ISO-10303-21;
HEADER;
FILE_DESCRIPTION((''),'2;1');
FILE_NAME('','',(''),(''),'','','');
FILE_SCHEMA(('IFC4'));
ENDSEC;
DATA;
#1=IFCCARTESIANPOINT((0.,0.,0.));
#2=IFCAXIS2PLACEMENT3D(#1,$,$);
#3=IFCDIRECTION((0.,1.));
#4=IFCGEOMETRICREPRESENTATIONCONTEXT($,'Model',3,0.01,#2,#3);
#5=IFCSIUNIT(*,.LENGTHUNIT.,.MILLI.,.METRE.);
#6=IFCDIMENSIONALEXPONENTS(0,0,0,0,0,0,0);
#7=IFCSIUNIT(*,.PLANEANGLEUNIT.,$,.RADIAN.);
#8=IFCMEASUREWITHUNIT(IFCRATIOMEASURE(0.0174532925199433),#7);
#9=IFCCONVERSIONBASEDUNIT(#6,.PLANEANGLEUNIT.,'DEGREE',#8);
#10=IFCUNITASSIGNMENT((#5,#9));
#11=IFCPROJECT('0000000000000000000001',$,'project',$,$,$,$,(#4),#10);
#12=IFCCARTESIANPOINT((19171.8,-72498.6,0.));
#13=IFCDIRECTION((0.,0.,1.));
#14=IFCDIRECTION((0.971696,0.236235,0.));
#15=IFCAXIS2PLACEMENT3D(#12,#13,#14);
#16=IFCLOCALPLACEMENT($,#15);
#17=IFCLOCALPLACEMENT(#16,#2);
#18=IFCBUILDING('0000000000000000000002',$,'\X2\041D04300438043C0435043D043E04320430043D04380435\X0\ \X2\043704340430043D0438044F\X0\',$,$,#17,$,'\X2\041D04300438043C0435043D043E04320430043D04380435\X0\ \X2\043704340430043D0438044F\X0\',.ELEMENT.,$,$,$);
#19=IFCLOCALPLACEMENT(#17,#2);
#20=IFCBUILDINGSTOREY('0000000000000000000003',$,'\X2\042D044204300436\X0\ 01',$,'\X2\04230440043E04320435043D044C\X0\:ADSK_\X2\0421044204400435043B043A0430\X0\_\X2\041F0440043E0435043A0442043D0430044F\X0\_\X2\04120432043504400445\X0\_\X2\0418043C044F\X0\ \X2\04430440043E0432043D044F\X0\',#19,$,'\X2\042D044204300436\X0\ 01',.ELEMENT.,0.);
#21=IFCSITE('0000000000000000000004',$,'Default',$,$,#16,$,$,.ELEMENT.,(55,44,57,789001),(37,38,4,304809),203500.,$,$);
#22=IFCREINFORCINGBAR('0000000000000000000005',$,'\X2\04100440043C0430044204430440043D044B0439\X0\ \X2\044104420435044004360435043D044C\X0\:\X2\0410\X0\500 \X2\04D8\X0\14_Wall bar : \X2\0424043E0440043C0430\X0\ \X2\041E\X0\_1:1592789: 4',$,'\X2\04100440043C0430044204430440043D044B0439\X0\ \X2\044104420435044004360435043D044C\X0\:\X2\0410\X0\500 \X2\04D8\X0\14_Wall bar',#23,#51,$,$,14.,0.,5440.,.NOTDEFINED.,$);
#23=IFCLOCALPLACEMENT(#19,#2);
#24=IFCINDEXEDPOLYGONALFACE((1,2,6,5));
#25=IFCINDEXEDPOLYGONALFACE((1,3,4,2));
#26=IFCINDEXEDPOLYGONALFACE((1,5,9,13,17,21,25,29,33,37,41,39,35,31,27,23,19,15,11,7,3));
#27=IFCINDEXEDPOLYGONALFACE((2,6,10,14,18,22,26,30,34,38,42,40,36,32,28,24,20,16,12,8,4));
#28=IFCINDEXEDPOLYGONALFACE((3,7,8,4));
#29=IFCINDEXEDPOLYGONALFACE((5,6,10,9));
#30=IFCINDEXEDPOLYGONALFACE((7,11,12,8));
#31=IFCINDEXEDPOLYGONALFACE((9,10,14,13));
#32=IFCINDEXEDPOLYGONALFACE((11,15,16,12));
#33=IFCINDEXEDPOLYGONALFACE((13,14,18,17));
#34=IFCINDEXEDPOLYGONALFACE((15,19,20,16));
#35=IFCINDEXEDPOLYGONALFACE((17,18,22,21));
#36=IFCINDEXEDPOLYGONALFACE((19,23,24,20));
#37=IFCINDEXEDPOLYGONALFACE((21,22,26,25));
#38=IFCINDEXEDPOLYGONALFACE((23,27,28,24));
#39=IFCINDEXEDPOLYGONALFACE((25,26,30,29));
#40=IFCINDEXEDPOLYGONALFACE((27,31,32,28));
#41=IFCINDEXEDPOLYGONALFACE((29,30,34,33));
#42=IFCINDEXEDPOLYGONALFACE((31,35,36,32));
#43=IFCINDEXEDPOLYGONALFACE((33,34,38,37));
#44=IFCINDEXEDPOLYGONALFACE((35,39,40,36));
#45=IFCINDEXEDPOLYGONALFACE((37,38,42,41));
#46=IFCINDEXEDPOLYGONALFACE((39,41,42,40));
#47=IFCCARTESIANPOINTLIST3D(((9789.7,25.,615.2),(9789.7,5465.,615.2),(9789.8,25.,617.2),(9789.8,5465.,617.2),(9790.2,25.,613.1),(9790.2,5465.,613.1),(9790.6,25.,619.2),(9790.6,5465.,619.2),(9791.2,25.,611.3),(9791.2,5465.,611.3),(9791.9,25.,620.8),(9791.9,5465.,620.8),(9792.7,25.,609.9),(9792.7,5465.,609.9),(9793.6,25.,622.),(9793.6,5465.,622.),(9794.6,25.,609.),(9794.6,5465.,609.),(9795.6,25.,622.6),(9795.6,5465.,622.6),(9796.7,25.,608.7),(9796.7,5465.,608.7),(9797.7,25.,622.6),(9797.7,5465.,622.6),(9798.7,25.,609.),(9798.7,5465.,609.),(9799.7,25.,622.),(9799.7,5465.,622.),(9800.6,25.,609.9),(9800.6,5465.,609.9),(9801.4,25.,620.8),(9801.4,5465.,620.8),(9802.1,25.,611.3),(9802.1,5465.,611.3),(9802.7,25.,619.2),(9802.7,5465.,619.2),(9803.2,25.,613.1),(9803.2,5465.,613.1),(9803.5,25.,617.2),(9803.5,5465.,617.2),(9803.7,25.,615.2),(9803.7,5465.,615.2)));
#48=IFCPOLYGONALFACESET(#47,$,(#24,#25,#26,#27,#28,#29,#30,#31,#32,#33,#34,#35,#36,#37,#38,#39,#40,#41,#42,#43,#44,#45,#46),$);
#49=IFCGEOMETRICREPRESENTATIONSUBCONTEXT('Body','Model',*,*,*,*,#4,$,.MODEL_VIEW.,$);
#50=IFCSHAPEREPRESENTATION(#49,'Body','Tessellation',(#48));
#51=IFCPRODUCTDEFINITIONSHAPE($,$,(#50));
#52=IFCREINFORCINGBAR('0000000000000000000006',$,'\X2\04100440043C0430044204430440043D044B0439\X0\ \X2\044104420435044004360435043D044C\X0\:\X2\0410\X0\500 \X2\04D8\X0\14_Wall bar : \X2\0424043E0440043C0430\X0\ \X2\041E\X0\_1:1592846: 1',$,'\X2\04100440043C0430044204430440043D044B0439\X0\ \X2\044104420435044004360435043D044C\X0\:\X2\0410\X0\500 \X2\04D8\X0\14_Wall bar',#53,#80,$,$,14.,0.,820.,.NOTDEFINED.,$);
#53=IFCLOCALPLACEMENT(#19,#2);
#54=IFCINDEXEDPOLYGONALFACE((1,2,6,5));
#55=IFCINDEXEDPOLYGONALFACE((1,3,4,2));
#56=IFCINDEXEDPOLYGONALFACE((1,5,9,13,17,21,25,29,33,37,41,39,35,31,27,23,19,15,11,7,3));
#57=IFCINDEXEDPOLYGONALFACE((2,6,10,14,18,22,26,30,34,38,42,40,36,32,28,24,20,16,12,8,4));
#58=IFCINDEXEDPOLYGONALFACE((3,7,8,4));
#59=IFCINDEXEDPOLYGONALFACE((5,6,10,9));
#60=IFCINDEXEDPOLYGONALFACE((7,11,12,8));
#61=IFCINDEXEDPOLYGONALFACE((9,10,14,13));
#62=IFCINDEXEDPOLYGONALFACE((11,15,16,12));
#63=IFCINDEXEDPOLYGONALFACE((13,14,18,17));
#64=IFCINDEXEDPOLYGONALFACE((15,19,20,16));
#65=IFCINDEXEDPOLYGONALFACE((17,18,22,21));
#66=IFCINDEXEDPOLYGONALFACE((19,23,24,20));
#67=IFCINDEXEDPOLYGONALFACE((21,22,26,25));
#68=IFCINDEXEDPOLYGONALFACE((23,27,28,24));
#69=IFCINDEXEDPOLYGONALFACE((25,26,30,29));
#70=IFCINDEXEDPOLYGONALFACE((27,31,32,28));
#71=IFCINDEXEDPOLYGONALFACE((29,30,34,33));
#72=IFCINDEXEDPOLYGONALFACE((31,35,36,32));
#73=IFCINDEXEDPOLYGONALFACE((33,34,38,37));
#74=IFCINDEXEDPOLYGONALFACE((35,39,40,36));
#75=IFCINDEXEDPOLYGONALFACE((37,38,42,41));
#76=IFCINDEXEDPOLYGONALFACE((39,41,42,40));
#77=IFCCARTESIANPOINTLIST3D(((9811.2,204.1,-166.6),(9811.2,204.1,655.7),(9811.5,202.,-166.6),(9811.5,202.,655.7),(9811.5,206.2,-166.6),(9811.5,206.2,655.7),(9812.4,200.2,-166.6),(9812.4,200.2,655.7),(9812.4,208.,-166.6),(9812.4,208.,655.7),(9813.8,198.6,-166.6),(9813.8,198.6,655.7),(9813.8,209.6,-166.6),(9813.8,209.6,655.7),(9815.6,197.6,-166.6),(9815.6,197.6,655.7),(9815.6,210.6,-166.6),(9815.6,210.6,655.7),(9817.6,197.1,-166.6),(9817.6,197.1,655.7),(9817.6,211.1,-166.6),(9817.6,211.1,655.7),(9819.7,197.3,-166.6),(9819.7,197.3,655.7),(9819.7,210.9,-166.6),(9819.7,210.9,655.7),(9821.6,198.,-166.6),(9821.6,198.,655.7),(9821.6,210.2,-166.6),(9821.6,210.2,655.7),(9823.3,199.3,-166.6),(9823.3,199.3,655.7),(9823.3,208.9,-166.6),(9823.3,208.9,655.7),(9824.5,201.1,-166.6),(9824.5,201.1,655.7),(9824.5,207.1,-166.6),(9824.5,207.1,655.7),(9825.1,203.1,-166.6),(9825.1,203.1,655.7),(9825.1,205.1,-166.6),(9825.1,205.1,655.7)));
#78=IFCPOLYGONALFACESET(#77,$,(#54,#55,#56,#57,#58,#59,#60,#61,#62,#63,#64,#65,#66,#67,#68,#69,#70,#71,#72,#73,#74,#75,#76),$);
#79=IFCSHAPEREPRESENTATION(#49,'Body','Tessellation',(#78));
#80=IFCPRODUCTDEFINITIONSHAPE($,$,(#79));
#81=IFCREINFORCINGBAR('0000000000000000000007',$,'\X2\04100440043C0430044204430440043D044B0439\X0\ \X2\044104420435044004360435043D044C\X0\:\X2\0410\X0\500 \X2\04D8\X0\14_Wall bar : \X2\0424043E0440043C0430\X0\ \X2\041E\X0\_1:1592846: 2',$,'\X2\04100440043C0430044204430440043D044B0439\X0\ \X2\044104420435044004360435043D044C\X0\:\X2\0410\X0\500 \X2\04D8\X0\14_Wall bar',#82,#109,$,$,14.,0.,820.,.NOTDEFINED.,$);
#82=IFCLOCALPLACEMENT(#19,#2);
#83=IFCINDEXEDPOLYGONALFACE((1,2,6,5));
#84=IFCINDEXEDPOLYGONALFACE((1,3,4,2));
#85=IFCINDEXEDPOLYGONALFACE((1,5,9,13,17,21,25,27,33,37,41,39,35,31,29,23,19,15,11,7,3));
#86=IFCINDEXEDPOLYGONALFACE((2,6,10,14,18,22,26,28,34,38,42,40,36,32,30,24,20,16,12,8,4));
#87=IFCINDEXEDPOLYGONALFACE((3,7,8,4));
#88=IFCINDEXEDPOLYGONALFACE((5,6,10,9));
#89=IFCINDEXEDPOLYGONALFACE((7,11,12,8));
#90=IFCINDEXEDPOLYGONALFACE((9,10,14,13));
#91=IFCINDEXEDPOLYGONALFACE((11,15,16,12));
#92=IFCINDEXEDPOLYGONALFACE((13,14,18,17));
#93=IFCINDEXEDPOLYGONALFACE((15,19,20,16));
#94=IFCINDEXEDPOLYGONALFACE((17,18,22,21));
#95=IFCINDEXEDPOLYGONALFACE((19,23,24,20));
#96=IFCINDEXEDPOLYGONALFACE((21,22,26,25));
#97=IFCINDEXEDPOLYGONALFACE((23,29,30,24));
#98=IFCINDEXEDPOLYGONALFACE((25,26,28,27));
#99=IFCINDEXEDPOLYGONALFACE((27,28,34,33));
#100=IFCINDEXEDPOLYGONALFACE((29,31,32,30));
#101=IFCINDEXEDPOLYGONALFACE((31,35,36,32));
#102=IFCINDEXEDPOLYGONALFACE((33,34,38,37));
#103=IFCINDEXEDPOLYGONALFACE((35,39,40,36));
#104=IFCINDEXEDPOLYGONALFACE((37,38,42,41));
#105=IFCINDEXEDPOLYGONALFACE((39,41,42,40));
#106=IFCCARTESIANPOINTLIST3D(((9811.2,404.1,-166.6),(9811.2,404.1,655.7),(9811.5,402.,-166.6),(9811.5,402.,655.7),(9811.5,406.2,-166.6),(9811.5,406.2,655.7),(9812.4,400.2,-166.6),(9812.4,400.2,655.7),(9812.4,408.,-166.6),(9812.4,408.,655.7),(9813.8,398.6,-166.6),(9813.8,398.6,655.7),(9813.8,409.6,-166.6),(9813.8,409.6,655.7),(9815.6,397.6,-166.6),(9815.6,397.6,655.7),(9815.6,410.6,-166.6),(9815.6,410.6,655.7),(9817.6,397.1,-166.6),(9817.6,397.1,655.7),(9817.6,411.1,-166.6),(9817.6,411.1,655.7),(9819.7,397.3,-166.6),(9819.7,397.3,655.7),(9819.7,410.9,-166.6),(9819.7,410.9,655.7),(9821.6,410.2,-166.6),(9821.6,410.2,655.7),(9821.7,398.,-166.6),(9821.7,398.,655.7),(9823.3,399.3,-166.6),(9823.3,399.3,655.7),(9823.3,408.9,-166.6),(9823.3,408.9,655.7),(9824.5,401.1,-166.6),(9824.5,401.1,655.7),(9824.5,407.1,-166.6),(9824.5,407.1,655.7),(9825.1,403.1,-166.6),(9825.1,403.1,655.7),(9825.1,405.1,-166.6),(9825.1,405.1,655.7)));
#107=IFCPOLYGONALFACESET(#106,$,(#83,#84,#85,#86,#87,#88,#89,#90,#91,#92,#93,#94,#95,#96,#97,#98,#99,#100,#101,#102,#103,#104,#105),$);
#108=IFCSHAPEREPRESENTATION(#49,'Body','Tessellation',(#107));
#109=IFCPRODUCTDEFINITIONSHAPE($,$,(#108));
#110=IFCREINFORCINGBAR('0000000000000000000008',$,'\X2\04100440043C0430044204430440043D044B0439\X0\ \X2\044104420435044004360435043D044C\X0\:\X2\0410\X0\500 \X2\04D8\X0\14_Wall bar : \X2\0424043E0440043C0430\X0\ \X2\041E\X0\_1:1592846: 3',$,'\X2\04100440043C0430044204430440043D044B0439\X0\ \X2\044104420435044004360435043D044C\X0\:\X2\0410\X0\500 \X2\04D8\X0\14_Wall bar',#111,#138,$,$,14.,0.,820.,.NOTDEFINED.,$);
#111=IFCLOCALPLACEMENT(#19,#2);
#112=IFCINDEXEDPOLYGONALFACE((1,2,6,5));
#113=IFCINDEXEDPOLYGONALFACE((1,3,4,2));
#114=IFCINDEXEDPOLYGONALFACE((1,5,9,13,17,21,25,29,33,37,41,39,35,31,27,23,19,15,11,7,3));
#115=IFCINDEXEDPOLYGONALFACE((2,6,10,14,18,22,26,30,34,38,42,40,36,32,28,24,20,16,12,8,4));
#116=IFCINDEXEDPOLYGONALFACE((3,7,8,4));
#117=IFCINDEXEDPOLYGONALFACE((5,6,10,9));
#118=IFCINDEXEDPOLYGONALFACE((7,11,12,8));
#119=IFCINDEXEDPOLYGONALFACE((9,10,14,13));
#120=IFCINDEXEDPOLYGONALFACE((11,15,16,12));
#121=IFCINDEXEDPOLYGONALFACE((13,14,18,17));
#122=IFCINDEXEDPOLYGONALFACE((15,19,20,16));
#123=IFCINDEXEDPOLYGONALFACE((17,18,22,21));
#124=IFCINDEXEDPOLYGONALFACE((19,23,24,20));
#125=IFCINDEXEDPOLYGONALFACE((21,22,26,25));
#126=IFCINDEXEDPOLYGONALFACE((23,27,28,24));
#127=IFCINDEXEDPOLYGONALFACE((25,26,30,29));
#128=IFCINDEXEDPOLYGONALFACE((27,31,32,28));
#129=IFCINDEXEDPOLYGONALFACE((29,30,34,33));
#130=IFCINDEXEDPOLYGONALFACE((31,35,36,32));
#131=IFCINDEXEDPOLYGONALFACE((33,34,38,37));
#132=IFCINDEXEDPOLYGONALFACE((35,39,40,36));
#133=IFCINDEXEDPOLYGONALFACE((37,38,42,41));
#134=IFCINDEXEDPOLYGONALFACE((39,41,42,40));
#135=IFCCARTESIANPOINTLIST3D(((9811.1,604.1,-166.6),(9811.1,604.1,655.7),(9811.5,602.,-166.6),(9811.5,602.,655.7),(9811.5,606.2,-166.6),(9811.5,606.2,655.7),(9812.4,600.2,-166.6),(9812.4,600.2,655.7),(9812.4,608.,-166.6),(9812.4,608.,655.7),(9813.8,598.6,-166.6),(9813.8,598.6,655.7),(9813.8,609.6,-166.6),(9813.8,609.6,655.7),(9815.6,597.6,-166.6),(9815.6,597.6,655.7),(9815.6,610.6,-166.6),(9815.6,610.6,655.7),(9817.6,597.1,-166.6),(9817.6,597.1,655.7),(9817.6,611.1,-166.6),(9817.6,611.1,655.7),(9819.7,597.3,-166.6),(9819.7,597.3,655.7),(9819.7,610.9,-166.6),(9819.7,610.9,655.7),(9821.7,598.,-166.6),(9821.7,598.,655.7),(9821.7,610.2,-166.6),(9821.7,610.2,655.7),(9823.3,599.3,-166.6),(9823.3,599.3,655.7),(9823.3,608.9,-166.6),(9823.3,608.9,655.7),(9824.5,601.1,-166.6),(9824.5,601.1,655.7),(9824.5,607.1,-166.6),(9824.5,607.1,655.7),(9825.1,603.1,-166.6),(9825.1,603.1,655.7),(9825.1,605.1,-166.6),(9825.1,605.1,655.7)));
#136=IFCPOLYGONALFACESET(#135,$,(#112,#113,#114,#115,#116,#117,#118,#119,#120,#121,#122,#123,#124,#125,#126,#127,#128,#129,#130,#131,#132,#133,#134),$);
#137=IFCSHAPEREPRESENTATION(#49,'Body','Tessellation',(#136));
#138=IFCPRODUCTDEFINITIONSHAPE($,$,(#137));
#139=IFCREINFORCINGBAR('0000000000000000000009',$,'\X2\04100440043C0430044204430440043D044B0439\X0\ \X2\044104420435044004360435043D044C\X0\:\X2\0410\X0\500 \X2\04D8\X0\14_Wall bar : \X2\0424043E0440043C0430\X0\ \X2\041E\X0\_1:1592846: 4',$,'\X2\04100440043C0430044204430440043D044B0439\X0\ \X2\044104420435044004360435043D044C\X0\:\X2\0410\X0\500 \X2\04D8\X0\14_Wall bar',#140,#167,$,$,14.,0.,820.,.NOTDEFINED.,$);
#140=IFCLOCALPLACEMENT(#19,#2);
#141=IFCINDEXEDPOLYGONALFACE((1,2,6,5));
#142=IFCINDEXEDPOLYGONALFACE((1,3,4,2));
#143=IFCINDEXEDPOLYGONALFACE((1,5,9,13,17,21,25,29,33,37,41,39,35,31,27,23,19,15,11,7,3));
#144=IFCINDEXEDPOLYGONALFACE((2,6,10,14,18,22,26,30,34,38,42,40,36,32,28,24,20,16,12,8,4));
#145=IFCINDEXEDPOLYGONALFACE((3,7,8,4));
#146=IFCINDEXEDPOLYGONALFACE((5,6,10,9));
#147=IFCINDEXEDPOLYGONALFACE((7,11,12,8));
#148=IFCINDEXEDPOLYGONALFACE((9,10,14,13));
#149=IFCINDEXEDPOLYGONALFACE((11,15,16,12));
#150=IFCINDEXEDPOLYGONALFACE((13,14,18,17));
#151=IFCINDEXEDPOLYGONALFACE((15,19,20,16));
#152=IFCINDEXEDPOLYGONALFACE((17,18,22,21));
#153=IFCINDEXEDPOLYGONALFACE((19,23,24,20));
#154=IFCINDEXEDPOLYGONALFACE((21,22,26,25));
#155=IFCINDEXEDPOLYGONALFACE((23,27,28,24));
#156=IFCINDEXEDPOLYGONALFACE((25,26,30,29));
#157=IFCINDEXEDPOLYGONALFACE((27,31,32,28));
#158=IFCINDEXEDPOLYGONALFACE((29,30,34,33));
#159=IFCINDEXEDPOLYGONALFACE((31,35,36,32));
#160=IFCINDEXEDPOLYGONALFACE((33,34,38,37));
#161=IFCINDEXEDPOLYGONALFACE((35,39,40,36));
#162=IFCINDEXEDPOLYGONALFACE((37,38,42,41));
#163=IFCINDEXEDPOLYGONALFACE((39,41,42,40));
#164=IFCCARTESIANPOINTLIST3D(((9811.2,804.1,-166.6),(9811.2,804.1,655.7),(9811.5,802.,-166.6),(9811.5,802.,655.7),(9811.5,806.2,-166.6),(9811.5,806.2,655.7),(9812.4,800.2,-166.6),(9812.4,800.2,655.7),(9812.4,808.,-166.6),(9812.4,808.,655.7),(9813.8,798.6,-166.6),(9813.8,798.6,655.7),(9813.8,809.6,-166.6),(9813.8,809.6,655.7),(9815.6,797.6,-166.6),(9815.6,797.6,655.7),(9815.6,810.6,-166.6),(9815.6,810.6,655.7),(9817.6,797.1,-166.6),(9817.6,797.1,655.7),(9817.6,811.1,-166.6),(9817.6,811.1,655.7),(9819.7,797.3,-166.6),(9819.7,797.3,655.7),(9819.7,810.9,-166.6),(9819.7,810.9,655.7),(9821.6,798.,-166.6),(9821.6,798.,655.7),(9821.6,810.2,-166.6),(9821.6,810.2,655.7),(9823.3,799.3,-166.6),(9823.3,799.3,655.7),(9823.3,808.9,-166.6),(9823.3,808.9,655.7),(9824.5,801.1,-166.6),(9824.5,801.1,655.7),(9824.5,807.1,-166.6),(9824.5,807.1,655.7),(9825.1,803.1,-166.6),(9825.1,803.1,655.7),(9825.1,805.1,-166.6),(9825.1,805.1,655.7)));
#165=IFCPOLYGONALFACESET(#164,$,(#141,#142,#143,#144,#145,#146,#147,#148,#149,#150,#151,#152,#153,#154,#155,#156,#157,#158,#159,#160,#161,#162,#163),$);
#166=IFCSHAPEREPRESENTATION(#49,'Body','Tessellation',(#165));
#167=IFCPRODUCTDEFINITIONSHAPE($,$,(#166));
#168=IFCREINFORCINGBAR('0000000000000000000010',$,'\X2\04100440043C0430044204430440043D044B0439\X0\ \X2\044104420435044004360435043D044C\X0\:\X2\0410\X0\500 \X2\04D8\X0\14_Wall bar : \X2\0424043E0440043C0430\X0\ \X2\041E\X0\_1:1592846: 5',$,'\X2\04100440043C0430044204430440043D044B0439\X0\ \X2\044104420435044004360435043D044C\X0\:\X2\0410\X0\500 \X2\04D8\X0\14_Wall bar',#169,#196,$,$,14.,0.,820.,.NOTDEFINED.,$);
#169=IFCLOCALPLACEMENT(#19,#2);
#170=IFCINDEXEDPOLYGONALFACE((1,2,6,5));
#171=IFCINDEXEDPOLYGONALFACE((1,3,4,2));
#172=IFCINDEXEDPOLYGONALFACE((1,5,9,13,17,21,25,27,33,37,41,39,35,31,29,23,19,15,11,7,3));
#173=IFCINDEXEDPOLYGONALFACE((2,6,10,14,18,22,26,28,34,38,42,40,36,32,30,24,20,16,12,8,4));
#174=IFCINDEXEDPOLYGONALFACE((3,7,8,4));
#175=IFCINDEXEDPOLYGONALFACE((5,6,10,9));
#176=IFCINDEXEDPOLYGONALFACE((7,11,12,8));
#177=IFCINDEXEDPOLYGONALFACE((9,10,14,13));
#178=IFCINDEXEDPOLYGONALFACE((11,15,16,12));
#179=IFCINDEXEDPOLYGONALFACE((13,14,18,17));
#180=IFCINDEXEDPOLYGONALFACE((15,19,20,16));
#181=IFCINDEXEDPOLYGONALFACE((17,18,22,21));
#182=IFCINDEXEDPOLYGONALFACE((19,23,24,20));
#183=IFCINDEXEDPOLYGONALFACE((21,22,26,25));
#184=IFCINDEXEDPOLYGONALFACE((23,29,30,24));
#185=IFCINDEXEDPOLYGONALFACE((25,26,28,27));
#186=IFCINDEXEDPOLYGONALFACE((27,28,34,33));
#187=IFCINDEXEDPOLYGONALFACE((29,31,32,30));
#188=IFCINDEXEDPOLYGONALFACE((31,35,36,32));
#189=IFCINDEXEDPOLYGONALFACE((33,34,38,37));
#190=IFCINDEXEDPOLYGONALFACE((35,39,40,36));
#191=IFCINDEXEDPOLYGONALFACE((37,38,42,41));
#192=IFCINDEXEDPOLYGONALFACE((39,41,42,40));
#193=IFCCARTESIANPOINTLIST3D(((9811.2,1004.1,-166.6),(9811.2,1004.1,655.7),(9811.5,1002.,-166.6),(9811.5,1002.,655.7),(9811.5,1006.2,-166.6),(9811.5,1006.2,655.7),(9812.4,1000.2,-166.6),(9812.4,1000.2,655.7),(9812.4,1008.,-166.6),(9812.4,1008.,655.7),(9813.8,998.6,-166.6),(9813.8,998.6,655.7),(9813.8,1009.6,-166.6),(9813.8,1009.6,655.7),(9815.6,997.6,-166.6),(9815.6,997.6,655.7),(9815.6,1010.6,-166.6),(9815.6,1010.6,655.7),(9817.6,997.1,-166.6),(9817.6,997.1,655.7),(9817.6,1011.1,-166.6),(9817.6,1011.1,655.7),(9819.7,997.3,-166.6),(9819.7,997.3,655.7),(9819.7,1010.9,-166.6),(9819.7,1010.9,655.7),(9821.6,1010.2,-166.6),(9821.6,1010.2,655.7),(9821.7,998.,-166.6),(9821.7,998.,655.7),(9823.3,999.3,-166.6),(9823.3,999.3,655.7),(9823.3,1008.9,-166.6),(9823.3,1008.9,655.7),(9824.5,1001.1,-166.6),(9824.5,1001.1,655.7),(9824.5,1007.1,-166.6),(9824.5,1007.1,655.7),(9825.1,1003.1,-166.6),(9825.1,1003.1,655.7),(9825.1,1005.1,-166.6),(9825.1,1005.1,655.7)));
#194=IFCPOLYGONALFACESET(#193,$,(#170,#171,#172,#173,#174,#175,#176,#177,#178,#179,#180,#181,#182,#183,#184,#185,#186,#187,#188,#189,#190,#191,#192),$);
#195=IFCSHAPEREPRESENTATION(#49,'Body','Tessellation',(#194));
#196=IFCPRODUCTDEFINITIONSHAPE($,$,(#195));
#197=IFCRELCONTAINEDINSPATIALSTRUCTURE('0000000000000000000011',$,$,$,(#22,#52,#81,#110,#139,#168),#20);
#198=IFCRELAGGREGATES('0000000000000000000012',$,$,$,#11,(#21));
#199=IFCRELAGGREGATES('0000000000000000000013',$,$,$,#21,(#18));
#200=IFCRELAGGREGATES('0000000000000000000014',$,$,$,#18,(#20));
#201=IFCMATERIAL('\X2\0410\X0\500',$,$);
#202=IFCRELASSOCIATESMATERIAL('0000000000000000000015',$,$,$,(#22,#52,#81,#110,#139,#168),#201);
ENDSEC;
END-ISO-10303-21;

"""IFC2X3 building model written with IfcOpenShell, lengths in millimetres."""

from ifc_helpers import new_model, entity, si_unit, converted_unit, direction, frame, origin, place, context, subcontext, project, spatial, material, element, save


model = new_model("IFC2X3")

# Units and contexts
model_context = context("Model", 3, precision=0.01, world=origin(), true_north=direction((0.0, 1.0)))
body_context = subcontext(model_context, "Body", "Model", "MODEL_VIEW")
ifc_project = project(units=[si_unit("LENGTHUNIT", "METRE", prefix="MILLI"), converted_unit("PLANEANGLEUNIT", "DEGREE", entity("IfcRatioMeasure", 0.0174532925199433), si_unit("PLANEANGLEUNIT", "RADIAN"), dimensions=[0, 0, 0, 0, 0, 0, 0])], contexts=[model_context])

# Site, building, storey
site_placement = place(None, frame((19171.8, -72498.6, 0.0), z_axis=(0.0, 0.0, 1.0), x_axis=(0.971696, 0.236235, 0.0)))
site = spatial("IfcSite", under=ifc_project, at=site_placement, Name="Default", CompositionType="ELEMENT", RefLatitude=(55, 44, 57, 789001), RefLongitude=(37, 38, 4, 304809), RefElevation=203500.0)
building_placement = place(site_placement, origin())
building = spatial("IfcBuilding", under=site, at=building_placement, Name="Наименование здания", LongName="Наименование здания", CompositionType="ELEMENT")
storey_placement = place(building_placement, origin())
storey = spatial("IfcBuildingStorey", under=building, at=storey_placement, Name="Этаж 01", ObjectType="Уровень:ADSK_Стрелка_Проектная_Вверх_Имя уровня", LongName="Этаж 01", CompositionType="ELEMENT", Elevation=0.0)

# Reinforcing bars
ifc_material = material(Name="А500")
placement = place(storey_placement, origin())
element("IfcReinforcingBar", 1, at=placement, inside=storey, material=ifc_material, Name="Арматурный стержень:А500 Ә14_Wall bar : Форма О_1:1592789: 4", ObjectType="Арматурный стержень:А500 Ә14_Wall bar", BarLength=5440.0, BarRole="NOTDEFINED", CrossSectionArea=0.0, NominalDiameter=14.0, context=body_context, shape_type="AdvancedSweptSolid", body=[
    entity("IfcSweptDiskSolid", entity("IfcCompositeCurve", [entity("IfcCompositeCurveSegment", "CONTINUOUS", True, entity("IfcPolyline", [entity("IfcCartesianPoint", [9796.7, 5465.0, 615.7]), entity("IfcCartesianPoint", [9796.7, 25.0, 615.7])]))], False), 7.0, None, 0.0, 1.0),
])
element("IfcReinforcingBar", 2, at=placement, inside=storey, material=ifc_material, Name="Арматурный стержень:А500 Ә14_Wall bar : Форма О_1:1592846: 1", ObjectType="Арматурный стержень:А500 Ә14_Wall bar", BarLength=820.0, BarRole="NOTDEFINED", CrossSectionArea=0.0, NominalDiameter=14.0, context=body_context, shape_type="AdvancedSweptSolid", body=[
    entity("IfcSweptDiskSolid", entity("IfcCompositeCurve", [entity("IfcCompositeCurveSegment", "CONTINUOUS", True, entity("IfcPolyline", [entity("IfcCartesianPoint", [9818.1, 204.1, 655.7]), entity("IfcCartesianPoint", [9818.1, 204.1, -166.6])]))], False), 7.0, None, 0.0, 1.0),
])
element("IfcReinforcingBar", 3, at=placement, inside=storey, material=ifc_material, Name="Арматурный стержень:А500 Ә14_Wall bar : Форма О_1:1592846: 2", ObjectType="Арматурный стержень:А500 Ә14_Wall bar", BarLength=820.0, BarRole="NOTDEFINED", CrossSectionArea=0.0, NominalDiameter=14.0, context=body_context, shape_type="AdvancedSweptSolid", body=[
    entity("IfcSweptDiskSolid", entity("IfcCompositeCurve", [entity("IfcCompositeCurveSegment", "CONTINUOUS", True, entity("IfcPolyline", [entity("IfcCartesianPoint", [9818.1, 404.1, 655.7]), entity("IfcCartesianPoint", [9818.1, 404.1, -166.6])]))], False), 7.0, None, 0.0, 1.0),
])
element("IfcReinforcingBar", 4, at=placement, inside=storey, material=ifc_material, Name="Арматурный стержень:А500 Ә14_Wall bar : Форма О_1:1592846: 3", ObjectType="Арматурный стержень:А500 Ә14_Wall bar", BarLength=820.0, BarRole="NOTDEFINED", CrossSectionArea=0.0, NominalDiameter=14.0, context=body_context, shape_type="AdvancedSweptSolid", body=[
    entity("IfcSweptDiskSolid", entity("IfcCompositeCurve", [entity("IfcCompositeCurveSegment", "CONTINUOUS", True, entity("IfcPolyline", [entity("IfcCartesianPoint", [9818.1, 604.1, 655.7]), entity("IfcCartesianPoint", [9818.1, 604.1, -166.6])]))], False), 7.0, None, 0.0, 1.0),
])
element("IfcReinforcingBar", 5, at=placement, inside=storey, material=ifc_material, Name="Арматурный стержень:А500 Ә14_Wall bar : Форма О_1:1592846: 4", ObjectType="Арматурный стержень:А500 Ә14_Wall bar", BarLength=820.0, BarRole="NOTDEFINED", CrossSectionArea=0.0, NominalDiameter=14.0, context=body_context, shape_type="AdvancedSweptSolid", body=[
    entity("IfcSweptDiskSolid", entity("IfcCompositeCurve", [entity("IfcCompositeCurveSegment", "CONTINUOUS", True, entity("IfcPolyline", [entity("IfcCartesianPoint", [9818.1, 804.1, 655.7]), entity("IfcCartesianPoint", [9818.1, 804.1, -166.6])]))], False), 7.0, None, 0.0, 1.0),
])
element("IfcReinforcingBar", 6, at=placement, inside=storey, material=ifc_material, Name="Арматурный стержень:А500 Ә14_Wall bar : Форма О_1:1592846: 5", ObjectType="Арматурный стержень:А500 Ә14_Wall bar", BarLength=820.0, BarRole="NOTDEFINED", CrossSectionArea=0.0, NominalDiameter=14.0, context=body_context, shape_type="AdvancedSweptSolid", body=[
    entity("IfcSweptDiskSolid", entity("IfcCompositeCurve", [entity("IfcCompositeCurveSegment", "CONTINUOUS", True, entity("IfcPolyline", [entity("IfcCartesianPoint", [9818.1, 1004.1, 655.7]), entity("IfcCartesianPoint", [9818.1, 1004.1, -166.6])]))], False), 7.0, None, 0.0, 1.0),
])

save(model, "model.ifc")
